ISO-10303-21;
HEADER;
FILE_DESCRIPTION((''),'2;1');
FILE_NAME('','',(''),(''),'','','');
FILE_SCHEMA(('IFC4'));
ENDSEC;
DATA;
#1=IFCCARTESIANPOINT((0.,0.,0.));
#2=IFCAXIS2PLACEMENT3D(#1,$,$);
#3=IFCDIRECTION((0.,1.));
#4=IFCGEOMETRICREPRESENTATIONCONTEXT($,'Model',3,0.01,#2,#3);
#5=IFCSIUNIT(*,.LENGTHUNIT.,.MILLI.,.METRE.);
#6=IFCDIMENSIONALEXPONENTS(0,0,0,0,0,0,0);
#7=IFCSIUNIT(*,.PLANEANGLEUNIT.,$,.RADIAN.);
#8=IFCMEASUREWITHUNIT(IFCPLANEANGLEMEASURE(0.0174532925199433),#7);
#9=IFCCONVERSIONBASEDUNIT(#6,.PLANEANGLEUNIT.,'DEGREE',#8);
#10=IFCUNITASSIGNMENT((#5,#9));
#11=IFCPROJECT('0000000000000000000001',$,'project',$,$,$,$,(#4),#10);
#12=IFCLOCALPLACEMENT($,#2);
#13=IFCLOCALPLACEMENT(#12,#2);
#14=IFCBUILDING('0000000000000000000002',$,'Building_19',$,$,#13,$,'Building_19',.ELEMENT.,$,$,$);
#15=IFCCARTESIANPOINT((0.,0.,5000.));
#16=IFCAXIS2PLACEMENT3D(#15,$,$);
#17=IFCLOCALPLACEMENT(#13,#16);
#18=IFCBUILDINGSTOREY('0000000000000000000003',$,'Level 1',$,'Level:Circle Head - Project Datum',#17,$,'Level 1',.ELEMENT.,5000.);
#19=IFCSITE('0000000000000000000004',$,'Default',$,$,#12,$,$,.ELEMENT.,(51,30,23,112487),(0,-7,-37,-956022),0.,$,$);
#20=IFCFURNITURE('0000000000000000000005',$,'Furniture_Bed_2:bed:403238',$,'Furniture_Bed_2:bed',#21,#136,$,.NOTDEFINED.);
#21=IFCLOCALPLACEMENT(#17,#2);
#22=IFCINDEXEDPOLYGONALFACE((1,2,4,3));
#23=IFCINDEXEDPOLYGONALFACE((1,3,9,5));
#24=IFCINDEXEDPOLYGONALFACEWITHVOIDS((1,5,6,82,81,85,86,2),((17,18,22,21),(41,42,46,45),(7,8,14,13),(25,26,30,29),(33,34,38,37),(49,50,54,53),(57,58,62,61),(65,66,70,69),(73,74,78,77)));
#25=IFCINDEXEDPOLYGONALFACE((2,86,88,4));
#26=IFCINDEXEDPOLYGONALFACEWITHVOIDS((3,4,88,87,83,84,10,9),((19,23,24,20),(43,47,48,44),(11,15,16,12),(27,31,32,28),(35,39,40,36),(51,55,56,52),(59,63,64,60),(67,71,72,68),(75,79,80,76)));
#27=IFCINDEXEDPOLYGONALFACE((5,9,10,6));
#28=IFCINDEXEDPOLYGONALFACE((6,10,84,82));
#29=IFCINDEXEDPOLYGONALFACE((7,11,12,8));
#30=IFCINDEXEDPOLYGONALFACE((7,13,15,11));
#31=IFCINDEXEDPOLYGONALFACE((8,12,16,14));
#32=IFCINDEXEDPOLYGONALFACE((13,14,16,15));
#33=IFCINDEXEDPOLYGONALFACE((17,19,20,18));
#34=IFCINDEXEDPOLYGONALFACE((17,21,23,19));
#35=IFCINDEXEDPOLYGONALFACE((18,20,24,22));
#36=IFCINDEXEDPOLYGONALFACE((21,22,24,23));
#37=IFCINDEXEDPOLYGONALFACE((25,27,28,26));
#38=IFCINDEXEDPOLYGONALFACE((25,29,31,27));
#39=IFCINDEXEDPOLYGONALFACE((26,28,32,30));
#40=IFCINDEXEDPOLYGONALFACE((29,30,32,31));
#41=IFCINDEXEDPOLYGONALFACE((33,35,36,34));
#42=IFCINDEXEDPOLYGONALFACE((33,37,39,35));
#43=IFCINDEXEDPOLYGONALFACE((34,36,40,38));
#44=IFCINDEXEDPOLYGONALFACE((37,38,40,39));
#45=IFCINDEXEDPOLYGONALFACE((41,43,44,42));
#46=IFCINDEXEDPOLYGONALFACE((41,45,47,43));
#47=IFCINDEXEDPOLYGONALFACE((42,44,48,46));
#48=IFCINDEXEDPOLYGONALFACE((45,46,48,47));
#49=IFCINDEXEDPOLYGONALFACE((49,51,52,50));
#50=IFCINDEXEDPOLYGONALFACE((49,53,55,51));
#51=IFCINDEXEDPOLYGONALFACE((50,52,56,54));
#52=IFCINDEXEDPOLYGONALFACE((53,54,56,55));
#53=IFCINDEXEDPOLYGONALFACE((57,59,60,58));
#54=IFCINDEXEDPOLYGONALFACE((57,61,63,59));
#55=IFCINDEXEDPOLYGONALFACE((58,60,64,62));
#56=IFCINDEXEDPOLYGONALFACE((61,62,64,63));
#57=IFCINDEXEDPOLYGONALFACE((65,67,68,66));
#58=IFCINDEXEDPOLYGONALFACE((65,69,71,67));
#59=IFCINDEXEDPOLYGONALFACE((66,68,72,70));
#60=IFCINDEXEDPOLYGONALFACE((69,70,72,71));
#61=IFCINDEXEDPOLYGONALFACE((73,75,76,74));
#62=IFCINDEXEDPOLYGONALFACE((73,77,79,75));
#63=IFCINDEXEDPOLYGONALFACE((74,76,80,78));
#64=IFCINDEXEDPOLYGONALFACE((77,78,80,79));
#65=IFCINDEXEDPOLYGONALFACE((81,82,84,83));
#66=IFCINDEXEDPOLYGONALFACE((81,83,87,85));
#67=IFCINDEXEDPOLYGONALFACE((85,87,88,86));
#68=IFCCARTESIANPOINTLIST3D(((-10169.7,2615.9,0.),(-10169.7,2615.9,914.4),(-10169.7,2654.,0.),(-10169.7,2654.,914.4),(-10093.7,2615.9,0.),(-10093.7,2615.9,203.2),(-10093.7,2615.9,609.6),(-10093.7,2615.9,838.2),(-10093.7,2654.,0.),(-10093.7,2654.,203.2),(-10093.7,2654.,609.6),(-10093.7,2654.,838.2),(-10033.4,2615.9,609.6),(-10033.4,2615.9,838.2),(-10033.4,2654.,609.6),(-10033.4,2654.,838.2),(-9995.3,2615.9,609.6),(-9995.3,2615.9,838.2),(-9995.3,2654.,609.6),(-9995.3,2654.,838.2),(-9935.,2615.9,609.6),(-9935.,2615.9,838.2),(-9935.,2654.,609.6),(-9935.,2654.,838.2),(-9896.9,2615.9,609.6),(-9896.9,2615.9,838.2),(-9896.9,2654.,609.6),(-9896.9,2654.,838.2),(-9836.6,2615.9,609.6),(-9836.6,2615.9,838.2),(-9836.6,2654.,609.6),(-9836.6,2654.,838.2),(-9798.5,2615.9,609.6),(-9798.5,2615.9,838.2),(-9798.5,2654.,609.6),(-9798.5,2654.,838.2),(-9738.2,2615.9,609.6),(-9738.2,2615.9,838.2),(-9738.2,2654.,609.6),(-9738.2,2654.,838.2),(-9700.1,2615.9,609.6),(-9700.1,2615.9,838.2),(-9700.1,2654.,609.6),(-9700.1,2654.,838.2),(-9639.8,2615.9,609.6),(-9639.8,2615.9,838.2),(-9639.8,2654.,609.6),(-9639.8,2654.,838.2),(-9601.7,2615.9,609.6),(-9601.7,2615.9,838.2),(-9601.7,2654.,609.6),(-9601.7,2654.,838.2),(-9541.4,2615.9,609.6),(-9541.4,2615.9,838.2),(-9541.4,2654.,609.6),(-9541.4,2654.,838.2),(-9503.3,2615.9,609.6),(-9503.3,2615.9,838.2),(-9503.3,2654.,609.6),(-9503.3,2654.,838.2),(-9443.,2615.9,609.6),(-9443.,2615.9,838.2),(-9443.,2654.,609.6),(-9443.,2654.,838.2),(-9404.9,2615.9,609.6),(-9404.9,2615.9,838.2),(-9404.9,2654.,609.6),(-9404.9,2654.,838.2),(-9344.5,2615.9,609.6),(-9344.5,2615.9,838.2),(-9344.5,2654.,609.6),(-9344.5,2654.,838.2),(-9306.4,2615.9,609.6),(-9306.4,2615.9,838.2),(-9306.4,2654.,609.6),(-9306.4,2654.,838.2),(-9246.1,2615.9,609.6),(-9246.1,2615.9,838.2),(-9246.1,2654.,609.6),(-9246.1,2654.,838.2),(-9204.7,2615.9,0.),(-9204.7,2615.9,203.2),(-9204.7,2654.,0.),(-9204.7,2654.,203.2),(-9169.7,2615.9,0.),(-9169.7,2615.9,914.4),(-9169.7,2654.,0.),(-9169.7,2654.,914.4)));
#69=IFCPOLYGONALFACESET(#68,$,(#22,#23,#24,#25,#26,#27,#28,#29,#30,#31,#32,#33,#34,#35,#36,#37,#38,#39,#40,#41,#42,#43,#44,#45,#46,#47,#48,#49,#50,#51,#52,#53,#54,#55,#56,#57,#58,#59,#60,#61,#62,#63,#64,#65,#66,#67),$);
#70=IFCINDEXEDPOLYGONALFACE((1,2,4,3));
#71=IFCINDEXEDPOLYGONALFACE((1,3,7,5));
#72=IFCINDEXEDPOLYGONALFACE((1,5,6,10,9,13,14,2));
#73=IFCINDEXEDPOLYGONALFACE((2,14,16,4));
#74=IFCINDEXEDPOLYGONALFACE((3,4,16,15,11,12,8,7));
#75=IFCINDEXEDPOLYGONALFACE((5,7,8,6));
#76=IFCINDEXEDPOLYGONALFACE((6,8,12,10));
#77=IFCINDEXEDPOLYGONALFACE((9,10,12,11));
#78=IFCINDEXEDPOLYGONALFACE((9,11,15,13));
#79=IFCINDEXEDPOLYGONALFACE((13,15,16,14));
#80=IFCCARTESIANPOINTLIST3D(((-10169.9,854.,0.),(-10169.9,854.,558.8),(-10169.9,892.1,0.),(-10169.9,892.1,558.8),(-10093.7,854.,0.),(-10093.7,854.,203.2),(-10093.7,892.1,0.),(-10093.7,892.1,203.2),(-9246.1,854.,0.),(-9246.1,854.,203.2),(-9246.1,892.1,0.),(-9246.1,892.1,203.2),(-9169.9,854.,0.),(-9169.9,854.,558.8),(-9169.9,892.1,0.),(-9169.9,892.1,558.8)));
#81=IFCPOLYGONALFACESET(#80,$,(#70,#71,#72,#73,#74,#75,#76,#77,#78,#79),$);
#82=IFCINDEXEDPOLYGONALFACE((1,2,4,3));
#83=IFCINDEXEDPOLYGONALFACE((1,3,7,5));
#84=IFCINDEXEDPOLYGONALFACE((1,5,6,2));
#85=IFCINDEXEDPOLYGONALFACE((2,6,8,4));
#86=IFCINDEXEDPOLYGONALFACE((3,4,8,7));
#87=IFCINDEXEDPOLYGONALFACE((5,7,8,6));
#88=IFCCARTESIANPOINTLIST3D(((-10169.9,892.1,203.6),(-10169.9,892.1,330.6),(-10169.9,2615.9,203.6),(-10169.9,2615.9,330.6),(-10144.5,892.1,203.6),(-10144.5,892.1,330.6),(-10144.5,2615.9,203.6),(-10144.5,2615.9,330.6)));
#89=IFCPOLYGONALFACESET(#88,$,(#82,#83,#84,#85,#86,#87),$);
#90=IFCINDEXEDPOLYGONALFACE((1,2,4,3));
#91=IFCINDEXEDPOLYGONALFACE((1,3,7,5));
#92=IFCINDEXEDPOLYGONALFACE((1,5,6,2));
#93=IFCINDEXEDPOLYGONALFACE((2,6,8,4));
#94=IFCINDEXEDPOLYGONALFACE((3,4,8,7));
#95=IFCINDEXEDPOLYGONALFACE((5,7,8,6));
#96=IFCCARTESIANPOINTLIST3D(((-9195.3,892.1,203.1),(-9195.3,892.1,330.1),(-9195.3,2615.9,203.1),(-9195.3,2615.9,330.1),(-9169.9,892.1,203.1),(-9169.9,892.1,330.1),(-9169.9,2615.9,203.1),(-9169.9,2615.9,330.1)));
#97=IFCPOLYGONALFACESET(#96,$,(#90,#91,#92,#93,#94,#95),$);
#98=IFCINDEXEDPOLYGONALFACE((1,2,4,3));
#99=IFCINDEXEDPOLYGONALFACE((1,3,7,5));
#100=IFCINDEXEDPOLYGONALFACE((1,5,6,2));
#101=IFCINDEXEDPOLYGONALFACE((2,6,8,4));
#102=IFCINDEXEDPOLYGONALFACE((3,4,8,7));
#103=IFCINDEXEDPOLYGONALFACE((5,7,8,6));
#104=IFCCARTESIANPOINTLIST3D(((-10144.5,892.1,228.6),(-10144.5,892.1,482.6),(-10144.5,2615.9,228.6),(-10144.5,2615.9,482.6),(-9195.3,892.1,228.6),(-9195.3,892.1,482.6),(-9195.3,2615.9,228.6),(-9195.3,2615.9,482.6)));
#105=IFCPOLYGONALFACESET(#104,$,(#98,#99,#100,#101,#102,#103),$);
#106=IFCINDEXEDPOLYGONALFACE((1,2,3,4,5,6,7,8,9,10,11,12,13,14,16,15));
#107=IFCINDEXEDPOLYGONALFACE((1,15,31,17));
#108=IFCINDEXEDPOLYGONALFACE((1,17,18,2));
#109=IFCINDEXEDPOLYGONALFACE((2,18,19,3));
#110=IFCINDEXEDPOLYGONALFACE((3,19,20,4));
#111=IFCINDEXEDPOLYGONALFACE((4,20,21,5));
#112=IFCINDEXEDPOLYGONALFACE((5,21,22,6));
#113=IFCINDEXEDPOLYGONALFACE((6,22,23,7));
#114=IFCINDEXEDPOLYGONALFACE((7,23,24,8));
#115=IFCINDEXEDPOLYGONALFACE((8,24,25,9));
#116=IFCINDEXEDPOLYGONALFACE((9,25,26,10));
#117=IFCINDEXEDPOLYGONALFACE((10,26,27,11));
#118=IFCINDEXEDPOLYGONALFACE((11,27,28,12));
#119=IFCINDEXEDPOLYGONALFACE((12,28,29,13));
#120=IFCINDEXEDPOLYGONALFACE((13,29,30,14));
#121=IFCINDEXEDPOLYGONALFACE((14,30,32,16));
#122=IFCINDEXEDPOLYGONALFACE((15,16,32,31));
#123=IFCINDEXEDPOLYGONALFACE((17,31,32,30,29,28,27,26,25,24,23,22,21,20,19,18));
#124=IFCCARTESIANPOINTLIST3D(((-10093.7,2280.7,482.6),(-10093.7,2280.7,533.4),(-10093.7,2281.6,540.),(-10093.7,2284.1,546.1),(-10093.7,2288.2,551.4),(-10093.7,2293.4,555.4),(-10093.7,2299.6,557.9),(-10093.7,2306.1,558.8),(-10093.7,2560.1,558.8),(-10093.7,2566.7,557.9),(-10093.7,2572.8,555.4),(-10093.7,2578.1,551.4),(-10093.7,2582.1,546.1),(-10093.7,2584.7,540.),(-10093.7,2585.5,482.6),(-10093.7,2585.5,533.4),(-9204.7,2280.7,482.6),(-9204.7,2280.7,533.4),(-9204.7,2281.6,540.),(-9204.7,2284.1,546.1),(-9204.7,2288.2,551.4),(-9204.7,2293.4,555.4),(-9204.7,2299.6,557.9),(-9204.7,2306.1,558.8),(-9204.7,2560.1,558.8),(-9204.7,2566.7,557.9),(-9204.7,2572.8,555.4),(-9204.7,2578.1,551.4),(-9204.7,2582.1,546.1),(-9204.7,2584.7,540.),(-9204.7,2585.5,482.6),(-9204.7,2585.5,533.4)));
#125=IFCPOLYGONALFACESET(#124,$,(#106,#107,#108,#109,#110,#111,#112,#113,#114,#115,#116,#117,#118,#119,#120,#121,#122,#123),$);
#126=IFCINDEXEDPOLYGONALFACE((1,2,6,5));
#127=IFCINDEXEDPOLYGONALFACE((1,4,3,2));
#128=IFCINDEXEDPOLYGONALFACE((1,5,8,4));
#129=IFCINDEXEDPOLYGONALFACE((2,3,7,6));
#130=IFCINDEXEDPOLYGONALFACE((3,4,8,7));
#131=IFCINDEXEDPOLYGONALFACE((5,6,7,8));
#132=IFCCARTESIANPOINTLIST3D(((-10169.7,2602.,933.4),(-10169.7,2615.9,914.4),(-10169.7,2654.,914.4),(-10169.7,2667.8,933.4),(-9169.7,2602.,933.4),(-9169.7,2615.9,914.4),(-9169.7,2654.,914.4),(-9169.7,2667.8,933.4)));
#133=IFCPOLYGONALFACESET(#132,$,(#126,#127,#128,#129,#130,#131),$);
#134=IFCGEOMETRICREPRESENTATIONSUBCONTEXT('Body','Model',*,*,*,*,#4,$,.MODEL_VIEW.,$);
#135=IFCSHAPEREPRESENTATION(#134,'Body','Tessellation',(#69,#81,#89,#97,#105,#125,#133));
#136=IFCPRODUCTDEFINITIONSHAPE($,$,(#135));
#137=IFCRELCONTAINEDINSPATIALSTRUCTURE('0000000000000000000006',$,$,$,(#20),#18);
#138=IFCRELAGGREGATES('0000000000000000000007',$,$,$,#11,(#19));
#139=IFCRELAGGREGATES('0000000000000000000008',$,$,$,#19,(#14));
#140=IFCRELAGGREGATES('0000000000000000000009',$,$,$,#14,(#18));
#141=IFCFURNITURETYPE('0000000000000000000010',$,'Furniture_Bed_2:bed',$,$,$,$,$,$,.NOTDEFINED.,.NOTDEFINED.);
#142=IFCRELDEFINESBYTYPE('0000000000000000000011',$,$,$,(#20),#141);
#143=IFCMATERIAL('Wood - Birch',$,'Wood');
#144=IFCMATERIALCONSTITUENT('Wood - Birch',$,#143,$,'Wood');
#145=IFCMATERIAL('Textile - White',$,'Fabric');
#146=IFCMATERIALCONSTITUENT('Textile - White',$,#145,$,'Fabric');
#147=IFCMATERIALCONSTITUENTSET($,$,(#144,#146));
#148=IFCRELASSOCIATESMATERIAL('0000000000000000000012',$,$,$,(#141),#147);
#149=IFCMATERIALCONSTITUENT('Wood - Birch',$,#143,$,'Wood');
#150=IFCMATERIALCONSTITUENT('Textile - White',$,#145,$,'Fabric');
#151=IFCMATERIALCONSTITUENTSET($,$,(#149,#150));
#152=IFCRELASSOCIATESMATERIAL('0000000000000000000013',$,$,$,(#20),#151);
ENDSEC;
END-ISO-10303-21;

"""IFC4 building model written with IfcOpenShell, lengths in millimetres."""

from ifc_helpers import new_model, entity, si_unit, converted_unit, direction, frame, origin, place, context, subcontext, project, spatial, line, arc, indexed_curve, outline, extrude, source, transform, mapped, material, constituent, constituent_set, type_object, type_shapes, element, save


model = new_model("IFC4")

# Units and contexts
model_context = context("Model", 3, precision=0.01, world=origin(), true_north=direction((0.0, 1.0)))
body_context = subcontext(model_context, "Body", "Model", "MODEL_VIEW")
ifc_project = project(units=[si_unit("LENGTHUNIT", "METRE", prefix="MILLI"), converted_unit("PLANEANGLEUNIT", "DEGREE", entity("IfcPlaneAngleMeasure", 0.0174532925199433), si_unit("PLANEANGLEUNIT", "RADIAN"), dimensions=[0, 0, 0, 0, 0, 0, 0])], contexts=[model_context])

# Site, building, storey
site_placement = place(None, origin())
site = spatial("IfcSite", under=ifc_project, at=site_placement, Name="Default", CompositionType="ELEMENT", RefLatitude=(51, 30, 23, 112487), RefLongitude=(0, -7, -37, -956022), RefElevation=0.0)
building_placement = place(site_placement, origin())
building = spatial("IfcBuilding", under=site, at=building_placement, Name="Building_19", LongName="Building_19", CompositionType="ELEMENT")
storey_placement = place(building_placement, frame((0.0, 0.0, 5000.0)))
storey = spatial("IfcBuildingStorey", under=building, at=storey_placement, Name="Level 1", ObjectType="Level:Circle Head - Project Datum", LongName="Level 1", CompositionType="ELEMENT", Elevation=5000.0)

# Furniture
ifc_material_1 = material(Name="Wood - Birch", Category="Wood")
ifc_material_2 = material(Name="Textile - White", Category="Fabric")
ifc_constituent_1 = constituent(ifc_material_1, Name="Wood - Birch", Category="Wood")
ifc_constituent_2 = constituent(ifc_material_2, Name="Textile - White", Category="Fabric")
ifc_constituent_set_1 = constituent_set(constituents=[ifc_constituent_1, ifc_constituent_2])
furniture_type_1 = type_object("IfcFurnitureType", Name="Furniture_Bed_2:bed", AssemblyPlace="NOTDEFINED", PredefinedType="NOTDEFINED", material=ifc_constituent_set_1)
shared_shape_1 = source(origin(), body_context, "Body", "SweptSolid", [
    extrude(outline(indexed_curve([(-635.0, -489.8), (279.4, -489.8), (279.4, -454.7), (76.2, -454.7), (76.2, 434.3), (279.4, 434.3), (279.4, 510.3), (-635.0, 510.3), (-635.0, -489.8)], self_intersect=False), holes=[indexed_curve([(-558.8, 374.0), (-558.8, 434.3), (-330.2, 434.3), (-330.2, 374.0), (-558.8, 374.0)], self_intersect=False), indexed_curve([(-558.8, 275.5), (-558.8, 335.9), (-330.2, 335.9), (-330.2, 275.5), (-558.8, 275.5)], self_intersect=False), indexed_curve([(-558.8, 177.1), (-558.8, 237.4), (-330.2, 237.4), (-330.2, 177.1), (-558.8, 177.1)], self_intersect=False), indexed_curve([(-558.8, 78.7), (-558.8, 139.0), (-330.2, 139.0), (-330.2, 78.7), (-558.8, 78.7)], self_intersect=False), indexed_curve([(-558.8, -118.1), (-558.8, -57.8), (-330.2, -57.8), (-330.2, -118.1), (-558.8, -118.1)], self_intersect=False), indexed_curve([(-558.8, -216.5), (-558.8, -156.2), (-330.2, -156.2), (-330.2, -216.5), (-558.8, -216.5)], self_intersect=False), indexed_curve([(-558.8, -314.9), (-558.8, -254.6), (-330.2, -254.6), (-330.2, -314.9), (-558.8, -314.9)], self_intersect=False), indexed_curve([(-558.8, -413.3), (-558.8, -353.0), (-330.2, -353.0), (-330.2, -413.3), (-558.8, -413.3)], self_intersect=False), indexed_curve([(-558.8, -19.7), (-558.8, 40.6), (-330.2, 40.6), (-330.2, -19.7), (-558.8, -19.7)], self_intersect=False)]), frame((-8.6, -38.1, 279.4), z_axis=(0.0, 1.0, 0.0), x_axis=(0.0, 0.0, -1.0)), (0.0, 0.0, 1.0), 38.1),
    extrude(outline(indexed_curve([(423.8, -190.5), (500.0, -190.5), (500.0, 368.3), (-500.0, 368.3), (-500.0, -190.5), (-423.8, -190.5), (-423.8, 12.7), (423.8, 12.7), (423.8, -190.5)], self_intersect=False)), frame((-19.1, -1800.0, 190.5), z_axis=(0.0, 1.0, 0.0), x_axis=(-1.0, 0.0, 0.0)), (0.0, 0.0, 1.0), 38.1),
    extrude(outline(indexed_curve([(-12.7, -861.9), (12.7, -861.9), (12.7, 861.9), (-12.7, 861.9), (-12.7, -861.9)], self_intersect=False)), frame((-506.4, -900.0, 203.6)), (0.0, 0.0, 1.0), 127.0),
    extrude(outline(indexed_curve([(-12.7, -861.9), (12.7, -861.9), (12.7, 861.9), (-12.7, 861.9), (-12.7, -861.9)], self_intersect=False)), frame((468.2, -900.0, 203.1)), (0.0, 0.0, 1.0), 127.0),
    extrude(outline(indexed_curve([(-474.6, -861.9), (474.6, -861.9), (474.6, 861.9), (-474.6, 861.9), (-474.6, -861.9)], self_intersect=False)), frame((-19.0, -900.0, 228.6), z_axis=(0.0, 0.0, 1.0), x_axis=(-1.0, 0.0, 0.0)), (0.0, 0.0, 1.0), 254.0),
    extrude(outline(indexed_curve([(-152.4, -42.3), (152.4, -42.3), (152.4, 8.5), (145.0, 26.4), (127.0, 33.9), (-127.0, 33.9), (-145.0, 26.4), (-152.4, 8.5)], segments=[line(1, 2, 3), arc(3, 4, 5), line(5, 6), arc(6, 7, 8), line(8, 1)], self_intersect=False)), frame((-442.9, -220.8, 524.9), z_axis=(1.0, 0.0, 0.0), x_axis=(0.0, 1.0, 0.0)), (0.0, 0.0, 1.0), 889.0),
    extrude(outline(indexed_curve([(-19.1, -9.5), (19.0, -9.5), (32.9, 9.5), (-32.9, 9.5), (-19.1, -9.5)], self_intersect=False)), frame((-518.8, -19.0, 923.9), z_axis=(1.0, 0.0, 0.0), x_axis=(0.0, 1.0, 0.0)), (0.0, 0.0, 1.0), 1000.1),
])
type_shapes(furniture_type_1, [shared_shape_1])
ifc_constituent_3 = constituent(ifc_material_1, Name="Wood - Birch", Category="Wood")
ifc_constituent_4 = constituent(ifc_material_2, Name="Textile - White", Category="Fabric")
ifc_constituent_set_2 = constituent_set(constituents=[ifc_constituent_3, ifc_constituent_4])
furniture_1_placement = place(storey_placement, frame((-9650.9, 2654.0, 0.0)))
element("IfcFurniture", 1, at=furniture_1_placement, inside=storey, type_object=furniture_type_1, material=ifc_constituent_set_2, Name="Furniture_Bed_2:bed:403238", ObjectType="Furniture_Bed_2:bed", PredefinedType="NOTDEFINED", context=body_context, shape_type="MappedRepresentation", body=[
    mapped(shared_shape_1, transform((0.0, 0.0, 0.0), scale=1.0)),
])

save(model, "model.ifc")
